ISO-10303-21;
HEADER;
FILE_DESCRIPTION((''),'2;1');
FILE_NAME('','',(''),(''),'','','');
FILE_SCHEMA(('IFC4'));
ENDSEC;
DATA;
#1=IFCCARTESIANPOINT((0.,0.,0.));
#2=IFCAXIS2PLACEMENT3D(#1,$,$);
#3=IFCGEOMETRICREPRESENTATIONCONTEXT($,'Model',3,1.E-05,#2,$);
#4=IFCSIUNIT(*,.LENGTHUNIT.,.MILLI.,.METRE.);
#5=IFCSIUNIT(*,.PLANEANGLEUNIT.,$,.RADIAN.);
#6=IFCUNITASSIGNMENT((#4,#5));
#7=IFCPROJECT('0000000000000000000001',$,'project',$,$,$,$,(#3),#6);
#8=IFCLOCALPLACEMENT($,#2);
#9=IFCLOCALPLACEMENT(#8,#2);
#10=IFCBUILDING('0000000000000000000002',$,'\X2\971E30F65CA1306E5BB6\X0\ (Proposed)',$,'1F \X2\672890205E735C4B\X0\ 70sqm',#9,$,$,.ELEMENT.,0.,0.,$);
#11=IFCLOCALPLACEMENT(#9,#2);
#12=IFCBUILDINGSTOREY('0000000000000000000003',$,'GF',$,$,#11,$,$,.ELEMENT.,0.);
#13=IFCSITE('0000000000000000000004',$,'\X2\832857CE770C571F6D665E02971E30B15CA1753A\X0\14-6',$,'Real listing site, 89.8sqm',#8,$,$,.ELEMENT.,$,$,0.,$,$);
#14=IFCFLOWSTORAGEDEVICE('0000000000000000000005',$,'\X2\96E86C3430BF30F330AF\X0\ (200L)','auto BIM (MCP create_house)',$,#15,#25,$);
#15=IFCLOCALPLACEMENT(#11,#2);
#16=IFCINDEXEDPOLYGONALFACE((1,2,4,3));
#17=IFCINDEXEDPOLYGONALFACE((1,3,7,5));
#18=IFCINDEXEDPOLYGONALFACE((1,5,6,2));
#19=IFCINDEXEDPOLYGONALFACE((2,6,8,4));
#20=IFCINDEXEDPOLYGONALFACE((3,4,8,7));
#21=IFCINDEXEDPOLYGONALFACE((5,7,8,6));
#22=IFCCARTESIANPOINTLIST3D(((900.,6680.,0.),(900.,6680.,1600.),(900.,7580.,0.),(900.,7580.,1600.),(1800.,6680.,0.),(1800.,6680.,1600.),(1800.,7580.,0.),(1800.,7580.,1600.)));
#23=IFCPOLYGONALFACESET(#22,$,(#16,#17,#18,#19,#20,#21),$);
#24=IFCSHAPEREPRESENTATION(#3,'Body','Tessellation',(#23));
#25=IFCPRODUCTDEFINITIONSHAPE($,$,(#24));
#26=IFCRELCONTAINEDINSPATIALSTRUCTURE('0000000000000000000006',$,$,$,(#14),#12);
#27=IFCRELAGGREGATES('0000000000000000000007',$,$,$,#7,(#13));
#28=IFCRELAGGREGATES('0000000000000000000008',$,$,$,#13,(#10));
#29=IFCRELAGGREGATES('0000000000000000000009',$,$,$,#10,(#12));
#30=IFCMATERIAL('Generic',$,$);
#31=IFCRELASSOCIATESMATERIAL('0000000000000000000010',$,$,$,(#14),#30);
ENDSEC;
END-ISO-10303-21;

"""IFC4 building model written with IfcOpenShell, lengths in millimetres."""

from ifc_helpers import new_model, si_unit, frame, frame_2d, origin, place, context, project, spatial, rectangle, extrude, material, element, save


model = new_model("IFC4")

# Units and contexts
model_context = context("Model", 3, precision=1e-05, world=origin())
ifc_project = project(units=[si_unit("LENGTHUNIT", "METRE", prefix="MILLI"), si_unit("PLANEANGLEUNIT", "RADIAN")], contexts=[model_context])

# Site, building, storey
site_placement = place(None, origin())
site = spatial("IfcSite", under=ifc_project, at=site_placement, Name="茨城県土浦市霞ケ岡町14-6", ObjectType="Real listing site, 89.8sqm", CompositionType="ELEMENT", RefElevation=0.0)
building_placement = place(site_placement, origin())
building = spatial("IfcBuilding", under=site, at=building_placement, Name="霞ヶ岡の家 (Proposed)", ObjectType="1F 木造平屋 70sqm", CompositionType="ELEMENT", ElevationOfRefHeight=0.0, ElevationOfTerrain=0.0)
storey_placement = place(building_placement, origin())
storey = spatial("IfcBuildingStorey", under=building, at=storey_placement, Name="GF", CompositionType="ELEMENT", Elevation=0.0)

# Shared definitions
ifc_material_1 = material(Name="Generic")

# Flow storage device
flow_storage_device_placement = place(storey_placement, frame((450.0, 3340.0, 0.0)))
element("IfcFlowStorageDevice", 1, at=flow_storage_device_placement, inside=storey, material=ifc_material_1, Name="雨水タンク (200L)", Description="auto BIM (MCP create_house)", context=model_context, shape_type="SweptSolid", body=[
    extrude(rectangle(XDim=900.0, YDim=900.0, at=frame_2d((450.0, 450.0))), frame((450.0, 3340.0, 0.0)), (0.0, 0.0, 1.0), 1600.0),
])

save(model, "model.ifc")
